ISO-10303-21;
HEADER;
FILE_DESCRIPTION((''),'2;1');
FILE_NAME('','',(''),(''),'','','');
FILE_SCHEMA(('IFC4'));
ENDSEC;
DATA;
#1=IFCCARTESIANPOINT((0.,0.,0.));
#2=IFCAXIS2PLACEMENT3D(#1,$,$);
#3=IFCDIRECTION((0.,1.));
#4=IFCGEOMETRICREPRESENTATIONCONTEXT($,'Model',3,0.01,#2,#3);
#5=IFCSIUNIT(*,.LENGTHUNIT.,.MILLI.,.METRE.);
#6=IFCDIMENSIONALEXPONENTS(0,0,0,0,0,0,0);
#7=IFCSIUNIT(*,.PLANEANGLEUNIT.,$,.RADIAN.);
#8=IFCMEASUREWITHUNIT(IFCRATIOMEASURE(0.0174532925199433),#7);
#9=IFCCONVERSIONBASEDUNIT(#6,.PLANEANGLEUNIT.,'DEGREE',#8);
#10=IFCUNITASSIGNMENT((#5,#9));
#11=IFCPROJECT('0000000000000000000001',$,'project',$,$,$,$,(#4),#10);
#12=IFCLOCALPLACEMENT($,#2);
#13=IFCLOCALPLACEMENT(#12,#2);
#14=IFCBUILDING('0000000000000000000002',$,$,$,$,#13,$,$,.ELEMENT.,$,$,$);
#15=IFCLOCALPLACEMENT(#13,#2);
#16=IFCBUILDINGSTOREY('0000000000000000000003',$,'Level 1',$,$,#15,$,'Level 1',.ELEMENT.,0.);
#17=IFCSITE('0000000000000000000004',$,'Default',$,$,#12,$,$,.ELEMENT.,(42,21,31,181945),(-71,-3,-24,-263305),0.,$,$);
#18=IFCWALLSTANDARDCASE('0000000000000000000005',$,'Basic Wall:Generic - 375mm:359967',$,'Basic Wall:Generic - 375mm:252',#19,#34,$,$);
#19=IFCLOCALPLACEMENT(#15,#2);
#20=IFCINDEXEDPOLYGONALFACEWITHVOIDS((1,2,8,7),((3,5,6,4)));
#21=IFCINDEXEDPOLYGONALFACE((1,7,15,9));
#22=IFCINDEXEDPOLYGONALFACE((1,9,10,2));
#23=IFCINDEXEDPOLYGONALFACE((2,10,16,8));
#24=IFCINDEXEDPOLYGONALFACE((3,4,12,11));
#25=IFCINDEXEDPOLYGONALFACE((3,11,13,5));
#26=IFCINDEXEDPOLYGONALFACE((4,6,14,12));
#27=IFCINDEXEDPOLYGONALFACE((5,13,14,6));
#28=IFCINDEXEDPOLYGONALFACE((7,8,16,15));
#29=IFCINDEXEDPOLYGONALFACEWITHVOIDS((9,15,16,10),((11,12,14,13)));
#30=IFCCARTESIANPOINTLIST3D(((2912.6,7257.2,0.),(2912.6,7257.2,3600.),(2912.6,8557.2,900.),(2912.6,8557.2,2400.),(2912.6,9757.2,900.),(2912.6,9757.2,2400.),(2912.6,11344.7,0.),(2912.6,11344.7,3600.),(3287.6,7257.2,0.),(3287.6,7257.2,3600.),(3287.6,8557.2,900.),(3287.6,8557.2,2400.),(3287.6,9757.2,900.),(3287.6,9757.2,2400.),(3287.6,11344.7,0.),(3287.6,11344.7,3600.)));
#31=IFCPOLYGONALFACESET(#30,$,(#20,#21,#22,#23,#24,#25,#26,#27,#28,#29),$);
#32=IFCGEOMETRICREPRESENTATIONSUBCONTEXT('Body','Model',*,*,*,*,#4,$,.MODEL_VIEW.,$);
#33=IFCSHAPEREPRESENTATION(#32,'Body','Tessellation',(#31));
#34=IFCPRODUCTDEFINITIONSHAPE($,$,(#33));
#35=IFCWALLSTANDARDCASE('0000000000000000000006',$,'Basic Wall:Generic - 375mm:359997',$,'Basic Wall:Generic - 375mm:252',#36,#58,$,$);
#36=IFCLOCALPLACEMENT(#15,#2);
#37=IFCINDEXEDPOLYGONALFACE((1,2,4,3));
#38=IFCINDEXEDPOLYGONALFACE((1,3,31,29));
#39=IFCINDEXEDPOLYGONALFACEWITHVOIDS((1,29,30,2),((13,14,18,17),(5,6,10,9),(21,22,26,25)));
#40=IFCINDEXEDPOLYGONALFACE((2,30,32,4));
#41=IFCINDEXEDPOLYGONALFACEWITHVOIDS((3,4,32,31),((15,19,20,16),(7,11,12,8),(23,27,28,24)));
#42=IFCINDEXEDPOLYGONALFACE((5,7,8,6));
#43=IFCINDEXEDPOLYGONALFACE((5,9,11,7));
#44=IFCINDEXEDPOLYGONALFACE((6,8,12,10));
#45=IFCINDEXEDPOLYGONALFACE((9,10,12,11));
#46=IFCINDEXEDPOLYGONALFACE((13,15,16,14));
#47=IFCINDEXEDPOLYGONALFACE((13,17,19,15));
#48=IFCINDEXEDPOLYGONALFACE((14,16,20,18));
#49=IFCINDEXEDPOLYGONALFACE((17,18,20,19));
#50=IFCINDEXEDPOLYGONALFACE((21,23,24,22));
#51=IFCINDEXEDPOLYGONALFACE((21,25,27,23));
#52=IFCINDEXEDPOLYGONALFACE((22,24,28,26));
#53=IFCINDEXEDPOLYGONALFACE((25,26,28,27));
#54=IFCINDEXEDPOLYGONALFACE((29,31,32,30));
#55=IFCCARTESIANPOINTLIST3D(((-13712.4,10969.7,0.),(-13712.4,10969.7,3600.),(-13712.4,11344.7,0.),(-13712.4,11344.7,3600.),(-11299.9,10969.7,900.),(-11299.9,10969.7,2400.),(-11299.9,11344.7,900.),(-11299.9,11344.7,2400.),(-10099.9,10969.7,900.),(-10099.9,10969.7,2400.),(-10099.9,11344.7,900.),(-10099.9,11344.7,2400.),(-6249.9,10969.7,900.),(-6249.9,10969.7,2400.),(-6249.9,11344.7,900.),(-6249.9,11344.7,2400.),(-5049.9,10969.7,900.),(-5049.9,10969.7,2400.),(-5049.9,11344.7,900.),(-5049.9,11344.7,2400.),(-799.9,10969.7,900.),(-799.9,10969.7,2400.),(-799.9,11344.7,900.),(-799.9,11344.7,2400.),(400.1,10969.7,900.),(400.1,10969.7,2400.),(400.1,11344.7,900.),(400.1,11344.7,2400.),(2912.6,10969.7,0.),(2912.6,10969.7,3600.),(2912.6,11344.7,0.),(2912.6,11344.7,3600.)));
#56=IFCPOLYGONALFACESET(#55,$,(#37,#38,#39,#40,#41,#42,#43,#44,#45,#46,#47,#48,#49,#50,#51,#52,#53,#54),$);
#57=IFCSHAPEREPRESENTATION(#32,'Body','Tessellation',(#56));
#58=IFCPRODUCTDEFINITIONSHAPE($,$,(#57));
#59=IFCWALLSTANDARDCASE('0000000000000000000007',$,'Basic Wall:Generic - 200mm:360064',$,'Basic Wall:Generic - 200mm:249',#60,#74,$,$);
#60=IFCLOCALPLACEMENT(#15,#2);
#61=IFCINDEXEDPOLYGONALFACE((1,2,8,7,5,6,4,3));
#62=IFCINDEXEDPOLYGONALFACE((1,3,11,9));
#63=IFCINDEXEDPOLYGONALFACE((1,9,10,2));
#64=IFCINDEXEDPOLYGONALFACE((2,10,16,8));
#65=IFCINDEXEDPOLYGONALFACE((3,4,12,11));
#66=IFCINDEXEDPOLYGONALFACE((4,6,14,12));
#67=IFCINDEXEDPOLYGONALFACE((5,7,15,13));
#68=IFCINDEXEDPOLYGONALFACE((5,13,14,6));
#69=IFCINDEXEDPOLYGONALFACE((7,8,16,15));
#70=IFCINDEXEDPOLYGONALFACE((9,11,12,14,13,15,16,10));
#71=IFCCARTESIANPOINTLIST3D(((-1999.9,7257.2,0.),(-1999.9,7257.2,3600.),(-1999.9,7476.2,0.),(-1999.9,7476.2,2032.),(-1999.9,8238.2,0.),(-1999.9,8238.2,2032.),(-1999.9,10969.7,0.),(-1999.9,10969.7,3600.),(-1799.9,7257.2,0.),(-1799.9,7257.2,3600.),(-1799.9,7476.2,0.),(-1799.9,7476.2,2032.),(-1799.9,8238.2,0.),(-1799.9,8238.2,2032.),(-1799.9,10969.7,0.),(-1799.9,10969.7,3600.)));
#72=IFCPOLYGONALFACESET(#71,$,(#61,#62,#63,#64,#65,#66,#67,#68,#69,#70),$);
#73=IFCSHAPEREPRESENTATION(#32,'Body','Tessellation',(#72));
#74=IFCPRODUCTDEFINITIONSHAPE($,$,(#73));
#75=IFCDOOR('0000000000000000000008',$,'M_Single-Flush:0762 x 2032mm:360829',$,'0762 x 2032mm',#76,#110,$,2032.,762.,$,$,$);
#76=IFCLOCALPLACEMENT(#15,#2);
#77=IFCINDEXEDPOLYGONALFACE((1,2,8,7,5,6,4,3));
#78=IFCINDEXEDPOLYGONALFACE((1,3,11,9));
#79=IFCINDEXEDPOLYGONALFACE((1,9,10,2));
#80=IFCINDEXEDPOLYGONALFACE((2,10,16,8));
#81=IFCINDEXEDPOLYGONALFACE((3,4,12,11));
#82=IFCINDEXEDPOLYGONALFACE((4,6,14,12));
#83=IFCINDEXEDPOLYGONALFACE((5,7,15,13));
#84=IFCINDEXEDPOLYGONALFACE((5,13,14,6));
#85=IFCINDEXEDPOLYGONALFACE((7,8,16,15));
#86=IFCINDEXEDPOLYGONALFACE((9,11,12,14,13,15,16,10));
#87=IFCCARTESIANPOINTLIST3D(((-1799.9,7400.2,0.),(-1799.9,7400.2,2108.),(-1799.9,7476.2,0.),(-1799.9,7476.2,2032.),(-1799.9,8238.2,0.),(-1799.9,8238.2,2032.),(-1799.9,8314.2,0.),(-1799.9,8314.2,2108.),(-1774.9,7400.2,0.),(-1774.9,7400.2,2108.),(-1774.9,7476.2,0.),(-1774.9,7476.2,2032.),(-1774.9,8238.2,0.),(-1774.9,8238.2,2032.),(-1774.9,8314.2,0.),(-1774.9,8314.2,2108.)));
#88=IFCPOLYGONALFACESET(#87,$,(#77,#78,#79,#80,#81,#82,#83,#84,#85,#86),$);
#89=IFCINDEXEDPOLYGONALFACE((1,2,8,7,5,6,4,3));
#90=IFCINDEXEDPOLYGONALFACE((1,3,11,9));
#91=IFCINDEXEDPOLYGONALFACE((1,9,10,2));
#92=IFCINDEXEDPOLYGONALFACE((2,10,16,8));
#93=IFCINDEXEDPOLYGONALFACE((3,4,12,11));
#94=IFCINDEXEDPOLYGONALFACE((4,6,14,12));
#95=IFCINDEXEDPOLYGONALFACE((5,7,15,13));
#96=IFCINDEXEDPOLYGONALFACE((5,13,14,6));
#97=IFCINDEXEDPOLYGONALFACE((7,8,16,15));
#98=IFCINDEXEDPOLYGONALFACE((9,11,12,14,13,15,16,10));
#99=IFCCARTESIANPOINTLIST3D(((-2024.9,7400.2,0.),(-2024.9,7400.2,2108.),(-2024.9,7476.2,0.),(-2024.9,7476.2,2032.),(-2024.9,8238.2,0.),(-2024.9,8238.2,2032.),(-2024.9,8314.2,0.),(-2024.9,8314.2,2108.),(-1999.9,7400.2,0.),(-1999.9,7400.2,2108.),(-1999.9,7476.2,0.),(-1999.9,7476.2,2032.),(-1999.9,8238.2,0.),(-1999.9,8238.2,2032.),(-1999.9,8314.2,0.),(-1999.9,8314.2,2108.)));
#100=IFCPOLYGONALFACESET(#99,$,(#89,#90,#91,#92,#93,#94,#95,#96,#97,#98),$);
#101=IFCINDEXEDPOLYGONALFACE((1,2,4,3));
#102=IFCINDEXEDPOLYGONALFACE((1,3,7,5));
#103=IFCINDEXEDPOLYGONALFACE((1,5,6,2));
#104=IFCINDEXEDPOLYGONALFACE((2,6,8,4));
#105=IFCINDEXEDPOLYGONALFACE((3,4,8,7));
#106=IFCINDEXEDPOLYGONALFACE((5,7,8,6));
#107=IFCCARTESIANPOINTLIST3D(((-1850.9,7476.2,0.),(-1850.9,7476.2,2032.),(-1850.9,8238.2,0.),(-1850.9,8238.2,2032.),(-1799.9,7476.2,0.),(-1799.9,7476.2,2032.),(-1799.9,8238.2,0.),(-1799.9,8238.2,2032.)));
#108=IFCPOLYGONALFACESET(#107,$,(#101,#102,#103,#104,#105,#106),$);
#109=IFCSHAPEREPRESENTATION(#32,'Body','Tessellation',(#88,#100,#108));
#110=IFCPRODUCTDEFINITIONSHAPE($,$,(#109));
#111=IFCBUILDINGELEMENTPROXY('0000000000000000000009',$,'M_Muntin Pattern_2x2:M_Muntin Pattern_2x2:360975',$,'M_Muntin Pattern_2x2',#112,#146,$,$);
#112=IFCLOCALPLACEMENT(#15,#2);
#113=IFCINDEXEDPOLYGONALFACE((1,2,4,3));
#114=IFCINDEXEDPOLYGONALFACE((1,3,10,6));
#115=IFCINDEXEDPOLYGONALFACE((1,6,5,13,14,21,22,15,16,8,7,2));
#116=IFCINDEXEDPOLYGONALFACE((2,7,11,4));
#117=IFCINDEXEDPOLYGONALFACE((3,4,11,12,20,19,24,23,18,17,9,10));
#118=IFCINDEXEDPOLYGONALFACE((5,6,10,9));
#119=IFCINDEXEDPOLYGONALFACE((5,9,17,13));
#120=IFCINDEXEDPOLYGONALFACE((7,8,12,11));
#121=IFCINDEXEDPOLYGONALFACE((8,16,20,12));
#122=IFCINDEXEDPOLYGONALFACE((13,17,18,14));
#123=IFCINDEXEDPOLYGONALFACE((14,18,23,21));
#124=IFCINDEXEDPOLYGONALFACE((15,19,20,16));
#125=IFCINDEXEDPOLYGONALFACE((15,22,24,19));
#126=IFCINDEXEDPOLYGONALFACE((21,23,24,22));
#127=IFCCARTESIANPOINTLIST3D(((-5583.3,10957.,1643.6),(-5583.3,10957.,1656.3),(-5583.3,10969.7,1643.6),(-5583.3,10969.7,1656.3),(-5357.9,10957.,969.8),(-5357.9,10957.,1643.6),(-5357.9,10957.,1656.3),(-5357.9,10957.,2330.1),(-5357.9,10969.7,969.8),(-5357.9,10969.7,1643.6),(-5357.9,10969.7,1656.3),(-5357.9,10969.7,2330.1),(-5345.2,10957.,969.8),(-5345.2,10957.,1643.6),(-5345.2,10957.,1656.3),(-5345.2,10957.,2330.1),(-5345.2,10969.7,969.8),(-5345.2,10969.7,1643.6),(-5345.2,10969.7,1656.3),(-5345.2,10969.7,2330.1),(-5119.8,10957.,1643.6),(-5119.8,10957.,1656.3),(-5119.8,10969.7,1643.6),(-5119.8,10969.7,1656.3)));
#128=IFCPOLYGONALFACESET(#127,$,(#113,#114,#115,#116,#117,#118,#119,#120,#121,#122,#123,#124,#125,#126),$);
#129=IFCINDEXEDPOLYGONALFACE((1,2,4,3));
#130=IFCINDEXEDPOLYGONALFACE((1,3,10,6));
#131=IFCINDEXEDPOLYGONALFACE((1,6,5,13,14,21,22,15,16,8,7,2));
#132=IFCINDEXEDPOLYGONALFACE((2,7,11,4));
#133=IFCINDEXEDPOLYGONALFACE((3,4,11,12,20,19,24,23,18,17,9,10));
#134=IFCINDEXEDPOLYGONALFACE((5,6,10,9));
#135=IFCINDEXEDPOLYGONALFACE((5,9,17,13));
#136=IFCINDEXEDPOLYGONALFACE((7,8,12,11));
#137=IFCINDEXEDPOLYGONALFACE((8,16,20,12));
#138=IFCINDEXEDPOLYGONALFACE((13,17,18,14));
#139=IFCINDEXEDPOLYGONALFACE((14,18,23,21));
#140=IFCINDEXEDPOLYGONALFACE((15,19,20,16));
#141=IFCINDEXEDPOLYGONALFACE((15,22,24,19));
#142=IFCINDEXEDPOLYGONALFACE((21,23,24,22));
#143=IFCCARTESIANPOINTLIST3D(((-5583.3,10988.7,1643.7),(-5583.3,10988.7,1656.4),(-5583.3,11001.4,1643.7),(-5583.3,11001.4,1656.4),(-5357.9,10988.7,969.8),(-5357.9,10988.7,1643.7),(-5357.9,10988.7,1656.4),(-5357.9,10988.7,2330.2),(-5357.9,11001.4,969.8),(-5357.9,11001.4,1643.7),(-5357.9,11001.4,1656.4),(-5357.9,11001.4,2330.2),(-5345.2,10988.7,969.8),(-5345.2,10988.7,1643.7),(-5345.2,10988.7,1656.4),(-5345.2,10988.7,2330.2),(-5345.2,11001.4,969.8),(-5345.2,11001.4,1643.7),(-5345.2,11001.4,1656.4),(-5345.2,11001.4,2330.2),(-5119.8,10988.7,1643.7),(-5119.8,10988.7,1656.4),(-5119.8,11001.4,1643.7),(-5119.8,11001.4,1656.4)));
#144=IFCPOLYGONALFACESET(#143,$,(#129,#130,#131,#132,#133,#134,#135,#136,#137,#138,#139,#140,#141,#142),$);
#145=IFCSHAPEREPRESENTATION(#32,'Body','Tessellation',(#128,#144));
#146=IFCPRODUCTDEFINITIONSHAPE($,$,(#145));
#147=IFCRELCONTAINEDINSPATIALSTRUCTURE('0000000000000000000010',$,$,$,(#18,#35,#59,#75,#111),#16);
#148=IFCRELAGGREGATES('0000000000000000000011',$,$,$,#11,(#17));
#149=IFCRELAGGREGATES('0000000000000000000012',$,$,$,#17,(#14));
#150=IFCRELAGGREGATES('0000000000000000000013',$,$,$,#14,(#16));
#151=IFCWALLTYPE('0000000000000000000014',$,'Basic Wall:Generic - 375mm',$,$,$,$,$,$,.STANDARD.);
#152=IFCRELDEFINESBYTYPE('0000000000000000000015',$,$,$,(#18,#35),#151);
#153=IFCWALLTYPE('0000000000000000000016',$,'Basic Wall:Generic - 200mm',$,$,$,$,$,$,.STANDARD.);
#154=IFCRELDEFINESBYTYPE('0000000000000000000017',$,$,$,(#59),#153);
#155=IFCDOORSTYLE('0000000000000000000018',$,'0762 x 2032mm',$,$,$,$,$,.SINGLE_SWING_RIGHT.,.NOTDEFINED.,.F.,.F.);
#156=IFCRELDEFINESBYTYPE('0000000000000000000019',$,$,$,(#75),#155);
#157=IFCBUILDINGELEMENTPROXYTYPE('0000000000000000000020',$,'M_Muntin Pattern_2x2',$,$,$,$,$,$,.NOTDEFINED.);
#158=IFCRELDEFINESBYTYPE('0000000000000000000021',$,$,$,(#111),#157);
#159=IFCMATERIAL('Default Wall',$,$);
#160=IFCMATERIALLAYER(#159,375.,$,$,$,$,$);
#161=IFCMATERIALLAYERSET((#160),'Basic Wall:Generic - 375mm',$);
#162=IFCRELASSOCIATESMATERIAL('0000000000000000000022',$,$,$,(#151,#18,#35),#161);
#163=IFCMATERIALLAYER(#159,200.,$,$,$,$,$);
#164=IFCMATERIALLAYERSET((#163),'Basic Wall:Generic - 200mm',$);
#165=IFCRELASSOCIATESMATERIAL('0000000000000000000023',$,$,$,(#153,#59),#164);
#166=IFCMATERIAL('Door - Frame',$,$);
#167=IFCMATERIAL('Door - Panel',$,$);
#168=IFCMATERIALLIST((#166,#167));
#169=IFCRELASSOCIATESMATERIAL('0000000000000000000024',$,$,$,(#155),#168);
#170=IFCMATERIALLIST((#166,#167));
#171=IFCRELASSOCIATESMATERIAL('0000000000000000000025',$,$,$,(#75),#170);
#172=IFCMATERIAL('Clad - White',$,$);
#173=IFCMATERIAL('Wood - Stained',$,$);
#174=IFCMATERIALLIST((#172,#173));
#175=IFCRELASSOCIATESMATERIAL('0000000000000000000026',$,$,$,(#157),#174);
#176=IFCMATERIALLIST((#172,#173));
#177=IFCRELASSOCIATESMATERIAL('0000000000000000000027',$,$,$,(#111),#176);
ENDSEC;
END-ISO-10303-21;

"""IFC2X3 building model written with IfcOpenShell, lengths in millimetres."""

from ifc_helpers import new_model, entity, si_unit, converted_unit, direction, frame, frame_2d, origin, place, context, subcontext, project, spatial, polyline, rectangle, outline, extrude, clip, bounded_halfspace, source, transform, mapped, material, material_list, layer, layer_set, layer_usage, type_object, type_shapes, element, fill, save


model = new_model("IFC2X3")

# Units and contexts
model_context = context("Model", 3, precision=0.01, world=origin(), true_north=direction((0.0, 1.0)))
body_context = subcontext(model_context, "Body", "Model", "MODEL_VIEW")
ifc_project = project(units=[si_unit("LENGTHUNIT", "METRE", prefix="MILLI"), converted_unit("PLANEANGLEUNIT", "DEGREE", entity("IfcRatioMeasure", 0.0174532925199433), si_unit("PLANEANGLEUNIT", "RADIAN"), dimensions=[0, 0, 0, 0, 0, 0, 0])], contexts=[model_context])

# Site, building, storey
site_placement = place(None, origin())
site = spatial("IfcSite", under=ifc_project, at=site_placement, Name="Default", CompositionType="ELEMENT", RefLatitude=(42, 21, 31, 181945), RefLongitude=(-71, -3, -24, -263305), RefElevation=0.0)
building_placement = place(site_placement, origin())
building = spatial("IfcBuilding", under=site, at=building_placement, CompositionType="ELEMENT")
storey_placement = place(building_placement, origin())
storey = spatial("IfcBuildingStorey", under=building, at=storey_placement, Name="Level 1", LongName="Level 1", CompositionType="ELEMENT", Elevation=0.0)

# Wall, opening
ifc_material_1 = material(Name="Default Wall")
ifc_layer_1 = layer(ifc_material_1, 375.0)
ifc_layer_set_1 = layer_set([ifc_layer_1], Name="Basic Wall:Generic - 375mm")
ifc_layer_usage_1 = layer_usage(ifc_layer_set_1, "AXIS2", "NEGATIVE", 187.5)
wall_type_1 = type_object("IfcWallType", Name="Basic Wall:Generic - 375mm", PredefinedType="STANDARD", material=ifc_layer_set_1)
wall_1_placement = place(storey_placement, frame((3100.1, 7257.2, 0.0), z_axis=(0.0, 0.0, 1.0), x_axis=(0.0, 1.0, 0.0)))
wall_1 = element("IfcWallStandardCase", 1, at=wall_1_placement, inside=storey, type_object=wall_type_1, material=ifc_layer_usage_1, Name="Basic Wall:Generic - 375mm:359967", ObjectType="Basic Wall:Generic - 375mm:252", context=body_context, shape_type="Clipping", body=[
    clip(extrude(rectangle(XDim=4087.5, YDim=375.0, at=frame_2d((2043.8, 0.0), x_axis=(-1.0, 0.0))), origin(), (0.0, 0.0, 1.0), 3600.0), bounded_halfspace(frame((0.0, -187.5, 3600.0), z_axis=(0.0, 0.0, -1.0), x_axis=(0.0, -1.0, 0.0)), True, frame((0.0, -187.5, 3600.0)), polyline([(0.0, 0.0), (4087.5, 0.0), (4087.5, 375.0), (3712.5, 375.0), (0.0, 375.0), (0.0, 0.0)]))),
])
opening_1_placement = place(wall_1_placement, frame((1300.0, -187.5, 900.0)))
element("IfcOpeningElement", 2, at=opening_1_placement, cuts=wall_1, ObjectType="Opening", context=body_context, shape_type="SweptSolid", body=[
    extrude(rectangle(XDim=1500.0, YDim=1200.0, at=frame_2d((750.0, 600.0), x_axis=(-1.0, 0.0))), frame((0.0, 0.0, 0.0), z_axis=(0.0, 1.0, 0.0), x_axis=(0.0, 0.0, 1.0)), (0.0, 0.0, 1.0), 375.0),
])

# Wall, openings
ifc_layer_usage_2 = layer_usage(ifc_layer_set_1, "AXIS2", "NEGATIVE", 187.5)
wall_2_placement = place(storey_placement, frame((2912.6, 11157.2, 0.0), z_axis=(0.0, 0.0, 1.0), x_axis=(-1.0, 0.0, 0.0)))
wall_2 = element("IfcWallStandardCase", 3, at=wall_2_placement, inside=storey, type_object=wall_type_1, material=ifc_layer_usage_2, Name="Basic Wall:Generic - 375mm:359997", ObjectType="Basic Wall:Generic - 375mm:252", context=body_context, shape_type="Clipping", body=[
    clip(extrude(rectangle(XDim=16625.0, YDim=375.0, at=frame_2d((8312.5, 0.0), x_axis=(-1.0, 0.0))), origin(), (0.0, 0.0, 1.0), 3600.0), bounded_halfspace(frame((0.0, -187.5, 3600.0), z_axis=(0.0, 0.0, -1.0), x_axis=(-1.0, 0.0, 0.0)), True, frame((0.0, -187.5, 3600.0)), polyline([(0.0, 0.0), (16625.0, 0.0), (16625.0, 375.0), (12412.5, 375.0), (12212.5, 375.0), (4912.5, 375.0), (4712.5, 375.0), (0.0, 375.0), (0.0, 0.0)]))),
])
opening_2_placement = place(wall_2_placement, frame((7962.5, -187.5, 900.0)))
element("IfcOpeningElement", 4, at=opening_2_placement, cuts=wall_2, ObjectType="Opening", context=body_context, shape_type="SweptSolid", body=[
    extrude(rectangle(XDim=1500.0, YDim=1200.0, at=frame_2d((750.0, 600.0), x_axis=(-1.0, 0.0))), frame((0.0, 0.0, 0.0), z_axis=(0.0, 1.0, 0.0), x_axis=(0.0, 0.0, 1.0)), (0.0, 0.0, 1.0), 375.0),
])
opening_3_placement = place(wall_2_placement, frame((2512.5, -187.5, 900.0)))
element("IfcOpeningElement", 5, at=opening_3_placement, cuts=wall_2, ObjectType="Opening", context=body_context, shape_type="SweptSolid", body=[
    extrude(rectangle(XDim=1500.0, YDim=1200.0, at=frame_2d((750.0, 600.0), x_axis=(-1.0, 0.0))), frame((0.0, 0.0, 0.0), z_axis=(0.0, 1.0, 0.0), x_axis=(0.0, 0.0, 1.0)), (0.0, 0.0, 1.0), 375.0),
])
opening_4_placement = place(wall_2_placement, frame((13012.5, -187.5, 900.0)))
element("IfcOpeningElement", 6, at=opening_4_placement, cuts=wall_2, ObjectType="Opening", context=body_context, shape_type="SweptSolid", body=[
    extrude(rectangle(XDim=1500.0, YDim=1200.0, at=frame_2d((750.0, 600.0), x_axis=(-1.0, 0.0))), frame((0.0, 0.0, 0.0), z_axis=(0.0, 1.0, 0.0), x_axis=(0.0, 0.0, 1.0)), (0.0, 0.0, 1.0), 375.0),
])

# Wall, opening, door
ifc_layer_2 = layer(ifc_material_1, 200.0)
ifc_layer_set_2 = layer_set([ifc_layer_2], Name="Basic Wall:Generic - 200mm")
ifc_layer_usage_3 = layer_usage(ifc_layer_set_2, "AXIS2", "NEGATIVE", 100.0)
wall_type_2 = type_object("IfcWallType", Name="Basic Wall:Generic - 200mm", PredefinedType="STANDARD", material=ifc_layer_set_2)
wall_3_placement = place(storey_placement, frame((-1899.9, 10969.7, 0.0), z_axis=(0.0, 0.0, 1.0), x_axis=(0.0, -1.0, 0.0)))
wall_3 = element("IfcWallStandardCase", 7, at=wall_3_placement, inside=storey, type_object=wall_type_2, material=ifc_layer_usage_3, Name="Basic Wall:Generic - 200mm:360064", ObjectType="Basic Wall:Generic - 200mm:249", context=body_context, shape_type="Clipping", body=[
    clip(extrude(rectangle(XDim=3712.5, YDim=200.0, at=frame_2d((1856.3, 0.0), x_axis=(-1.0, 0.0))), origin(), (0.0, 0.0, 1.0), 3600.0), bounded_halfspace(frame((0.0, -100.0, 3600.0), z_axis=(0.0, 0.0, -1.0), x_axis=(0.0, 1.0, 0.0)), True, frame((0.0, -100.0, 3600.0)), polyline([(0.0, 0.0), (3712.5, 0.0), (3712.5, 200.0), (0.0, 200.0), (0.0, 0.0)]))),
])
opening_5_placement = place(wall_3_placement, frame((2731.5, -100.0, 0.0)))
opening_5 = element("IfcOpeningElement", 8, at=opening_5_placement, cuts=wall_3, ObjectType="Opening", context=body_context, shape_type="SweptSolid", body=[
    extrude(rectangle(XDim=762.0, YDim=2032.0, at=frame_2d((1016.0, 381.0), x_axis=(0.0, 1.0))), frame((0.0, 0.0, 0.0), z_axis=(0.0, 1.0, 0.0), x_axis=(0.0, 0.0, 1.0)), (0.0, 0.0, 1.0), 200.0),
])
ifc_material_2 = material(Name="Door - Frame")
ifc_material_3 = material(Name="Door - Panel")
ifc_material_list_1 = material_list([ifc_material_2, ifc_material_3])
ifc_material_list_2 = material_list([ifc_material_2, ifc_material_3])
door_style = type_object("IfcDoorStyle", Name="0762 x 2032mm", ConstructionType="NOTDEFINED", OperationType="SINGLE_SWING_RIGHT", ParameterTakesPrecedence=False, Sizeable=False, material=ifc_material_list_2)
shared_shape_1 = source(origin(), body_context, "Body", "SweptSolid", [
    extrude(outline(polyline([(-457.0, -1073.0), (457.0, -1073.0), (457.0, 1035.0), (381.0, 1035.0), (381.0, -997.0), (-381.0, -997.0), (-381.0, 1035.0), (-457.0, 1035.0), (-457.0, -1073.0)])), frame((381.0, 200.0, 1035.0), z_axis=(0.0, 1.0, 0.0), x_axis=(1.0, 0.0, 0.0)), (0.0, 0.0, 1.0), 25.0),
    extrude(outline(polyline([(-1073.0, -457.0), (1035.0, -457.0), (1035.0, -381.0), (-997.0, -381.0), (-997.0, 381.0), (1035.0, 381.0), (1035.0, 457.0), (-1073.0, 457.0), (-1073.0, -457.0)])), frame((381.0, -25.0, 1035.0), z_axis=(0.0, 1.0, 0.0), x_axis=(0.0, 0.0, -1.0)), (0.0, 0.0, 1.0), 25.0),
    extrude(rectangle(XDim=51.0, YDim=762.0, at=frame_2d((0.0, 0.0), x_axis=(1.0, 0.0))), frame((381.0, 174.5, 0.0), z_axis=(0.0, 0.0, 1.0), x_axis=(0.0, 1.0, 0.0)), (0.0, 0.0, 1.0), 2032.0),
])
type_shapes(door_style, [shared_shape_1])
door_placement = place(opening_5_placement, origin())
door = element("IfcDoor", 9, at=door_placement, inside=storey, type_object=door_style, material=ifc_material_list_1, Name="M_Single-Flush:0762 x 2032mm:360829", ObjectType="0762 x 2032mm", OverallHeight=2032.0, OverallWidth=762.0, context=body_context, shape_type="MappedRepresentation", body=[
    mapped(shared_shape_1, transform((0.0, 0.0, 0.0), scale=1.0)),
])
fill(opening_5, door)

# Building element proxy
ifc_material_4 = material(Name="Clad - White")
ifc_material_5 = material(Name="Wood - Stained")
ifc_material_list_3 = material_list([ifc_material_4, ifc_material_5])
ifc_material_list_4 = material_list([ifc_material_4, ifc_material_5])
building_element_proxy_type_1 = type_object("IfcBuildingElementProxyType", Name="M_Muntin Pattern_2x2", PredefinedType="NOTDEFINED", material=ifc_material_list_4)
shared_shape_2 = source(origin(), body_context, "Body", "SweptSolid", [
    extrude(outline(polyline([(6.4, -6.4), (680.1, -6.4), (680.1, 6.3), (6.4, 6.3), (6.4, 231.7), (-6.3, 231.7), (-6.3, 6.3), (-680.2, 6.3), (-680.2, -6.4), (-6.3, -6.4), (-6.3, -231.7), (6.4, -231.7), (6.4, -6.4)])), frame((0.0, 9.5, 680.1), z_axis=(0.0, 1.0, 0.0), x_axis=(0.0, 0.0, 1.0)), (0.0, 0.0, 1.0), 12.7),
    extrude(outline(polyline([(6.4, -6.4), (680.2, -6.4), (680.2, 6.3), (6.4, 6.3), (6.4, 231.7), (-6.3, 231.7), (-6.3, 6.3), (-680.2, 6.3), (-680.2, -6.4), (-6.3, -6.4), (-6.3, -231.7), (6.4, -231.7), (6.4, -6.4)])), frame((0.0, -22.2, 680.2), z_axis=(0.0, 1.0, 0.0), x_axis=(0.0, 0.0, 1.0)), (0.0, 0.0, 1.0), 12.7),
])
type_shapes(building_element_proxy_type_1, [shared_shape_2])
proxy_1_placement = place(storey_placement, frame((-5351.5, 10979.2, 969.8), z_axis=(0.0, 0.0, 1.0), x_axis=(-1.0, 0.0, 0.0)))
element("IfcBuildingElementProxy", 10, at=proxy_1_placement, inside=storey, type_object=building_element_proxy_type_1, material=ifc_material_list_3, Name="M_Muntin Pattern_2x2:M_Muntin Pattern_2x2:360975", ObjectType="M_Muntin Pattern_2x2", context=body_context, shape_type="MappedRepresentation", body=[
    mapped(shared_shape_2, transform((0.0, 0.0, 0.0), scale=1.0)),
])

save(model, "model.ifc")
